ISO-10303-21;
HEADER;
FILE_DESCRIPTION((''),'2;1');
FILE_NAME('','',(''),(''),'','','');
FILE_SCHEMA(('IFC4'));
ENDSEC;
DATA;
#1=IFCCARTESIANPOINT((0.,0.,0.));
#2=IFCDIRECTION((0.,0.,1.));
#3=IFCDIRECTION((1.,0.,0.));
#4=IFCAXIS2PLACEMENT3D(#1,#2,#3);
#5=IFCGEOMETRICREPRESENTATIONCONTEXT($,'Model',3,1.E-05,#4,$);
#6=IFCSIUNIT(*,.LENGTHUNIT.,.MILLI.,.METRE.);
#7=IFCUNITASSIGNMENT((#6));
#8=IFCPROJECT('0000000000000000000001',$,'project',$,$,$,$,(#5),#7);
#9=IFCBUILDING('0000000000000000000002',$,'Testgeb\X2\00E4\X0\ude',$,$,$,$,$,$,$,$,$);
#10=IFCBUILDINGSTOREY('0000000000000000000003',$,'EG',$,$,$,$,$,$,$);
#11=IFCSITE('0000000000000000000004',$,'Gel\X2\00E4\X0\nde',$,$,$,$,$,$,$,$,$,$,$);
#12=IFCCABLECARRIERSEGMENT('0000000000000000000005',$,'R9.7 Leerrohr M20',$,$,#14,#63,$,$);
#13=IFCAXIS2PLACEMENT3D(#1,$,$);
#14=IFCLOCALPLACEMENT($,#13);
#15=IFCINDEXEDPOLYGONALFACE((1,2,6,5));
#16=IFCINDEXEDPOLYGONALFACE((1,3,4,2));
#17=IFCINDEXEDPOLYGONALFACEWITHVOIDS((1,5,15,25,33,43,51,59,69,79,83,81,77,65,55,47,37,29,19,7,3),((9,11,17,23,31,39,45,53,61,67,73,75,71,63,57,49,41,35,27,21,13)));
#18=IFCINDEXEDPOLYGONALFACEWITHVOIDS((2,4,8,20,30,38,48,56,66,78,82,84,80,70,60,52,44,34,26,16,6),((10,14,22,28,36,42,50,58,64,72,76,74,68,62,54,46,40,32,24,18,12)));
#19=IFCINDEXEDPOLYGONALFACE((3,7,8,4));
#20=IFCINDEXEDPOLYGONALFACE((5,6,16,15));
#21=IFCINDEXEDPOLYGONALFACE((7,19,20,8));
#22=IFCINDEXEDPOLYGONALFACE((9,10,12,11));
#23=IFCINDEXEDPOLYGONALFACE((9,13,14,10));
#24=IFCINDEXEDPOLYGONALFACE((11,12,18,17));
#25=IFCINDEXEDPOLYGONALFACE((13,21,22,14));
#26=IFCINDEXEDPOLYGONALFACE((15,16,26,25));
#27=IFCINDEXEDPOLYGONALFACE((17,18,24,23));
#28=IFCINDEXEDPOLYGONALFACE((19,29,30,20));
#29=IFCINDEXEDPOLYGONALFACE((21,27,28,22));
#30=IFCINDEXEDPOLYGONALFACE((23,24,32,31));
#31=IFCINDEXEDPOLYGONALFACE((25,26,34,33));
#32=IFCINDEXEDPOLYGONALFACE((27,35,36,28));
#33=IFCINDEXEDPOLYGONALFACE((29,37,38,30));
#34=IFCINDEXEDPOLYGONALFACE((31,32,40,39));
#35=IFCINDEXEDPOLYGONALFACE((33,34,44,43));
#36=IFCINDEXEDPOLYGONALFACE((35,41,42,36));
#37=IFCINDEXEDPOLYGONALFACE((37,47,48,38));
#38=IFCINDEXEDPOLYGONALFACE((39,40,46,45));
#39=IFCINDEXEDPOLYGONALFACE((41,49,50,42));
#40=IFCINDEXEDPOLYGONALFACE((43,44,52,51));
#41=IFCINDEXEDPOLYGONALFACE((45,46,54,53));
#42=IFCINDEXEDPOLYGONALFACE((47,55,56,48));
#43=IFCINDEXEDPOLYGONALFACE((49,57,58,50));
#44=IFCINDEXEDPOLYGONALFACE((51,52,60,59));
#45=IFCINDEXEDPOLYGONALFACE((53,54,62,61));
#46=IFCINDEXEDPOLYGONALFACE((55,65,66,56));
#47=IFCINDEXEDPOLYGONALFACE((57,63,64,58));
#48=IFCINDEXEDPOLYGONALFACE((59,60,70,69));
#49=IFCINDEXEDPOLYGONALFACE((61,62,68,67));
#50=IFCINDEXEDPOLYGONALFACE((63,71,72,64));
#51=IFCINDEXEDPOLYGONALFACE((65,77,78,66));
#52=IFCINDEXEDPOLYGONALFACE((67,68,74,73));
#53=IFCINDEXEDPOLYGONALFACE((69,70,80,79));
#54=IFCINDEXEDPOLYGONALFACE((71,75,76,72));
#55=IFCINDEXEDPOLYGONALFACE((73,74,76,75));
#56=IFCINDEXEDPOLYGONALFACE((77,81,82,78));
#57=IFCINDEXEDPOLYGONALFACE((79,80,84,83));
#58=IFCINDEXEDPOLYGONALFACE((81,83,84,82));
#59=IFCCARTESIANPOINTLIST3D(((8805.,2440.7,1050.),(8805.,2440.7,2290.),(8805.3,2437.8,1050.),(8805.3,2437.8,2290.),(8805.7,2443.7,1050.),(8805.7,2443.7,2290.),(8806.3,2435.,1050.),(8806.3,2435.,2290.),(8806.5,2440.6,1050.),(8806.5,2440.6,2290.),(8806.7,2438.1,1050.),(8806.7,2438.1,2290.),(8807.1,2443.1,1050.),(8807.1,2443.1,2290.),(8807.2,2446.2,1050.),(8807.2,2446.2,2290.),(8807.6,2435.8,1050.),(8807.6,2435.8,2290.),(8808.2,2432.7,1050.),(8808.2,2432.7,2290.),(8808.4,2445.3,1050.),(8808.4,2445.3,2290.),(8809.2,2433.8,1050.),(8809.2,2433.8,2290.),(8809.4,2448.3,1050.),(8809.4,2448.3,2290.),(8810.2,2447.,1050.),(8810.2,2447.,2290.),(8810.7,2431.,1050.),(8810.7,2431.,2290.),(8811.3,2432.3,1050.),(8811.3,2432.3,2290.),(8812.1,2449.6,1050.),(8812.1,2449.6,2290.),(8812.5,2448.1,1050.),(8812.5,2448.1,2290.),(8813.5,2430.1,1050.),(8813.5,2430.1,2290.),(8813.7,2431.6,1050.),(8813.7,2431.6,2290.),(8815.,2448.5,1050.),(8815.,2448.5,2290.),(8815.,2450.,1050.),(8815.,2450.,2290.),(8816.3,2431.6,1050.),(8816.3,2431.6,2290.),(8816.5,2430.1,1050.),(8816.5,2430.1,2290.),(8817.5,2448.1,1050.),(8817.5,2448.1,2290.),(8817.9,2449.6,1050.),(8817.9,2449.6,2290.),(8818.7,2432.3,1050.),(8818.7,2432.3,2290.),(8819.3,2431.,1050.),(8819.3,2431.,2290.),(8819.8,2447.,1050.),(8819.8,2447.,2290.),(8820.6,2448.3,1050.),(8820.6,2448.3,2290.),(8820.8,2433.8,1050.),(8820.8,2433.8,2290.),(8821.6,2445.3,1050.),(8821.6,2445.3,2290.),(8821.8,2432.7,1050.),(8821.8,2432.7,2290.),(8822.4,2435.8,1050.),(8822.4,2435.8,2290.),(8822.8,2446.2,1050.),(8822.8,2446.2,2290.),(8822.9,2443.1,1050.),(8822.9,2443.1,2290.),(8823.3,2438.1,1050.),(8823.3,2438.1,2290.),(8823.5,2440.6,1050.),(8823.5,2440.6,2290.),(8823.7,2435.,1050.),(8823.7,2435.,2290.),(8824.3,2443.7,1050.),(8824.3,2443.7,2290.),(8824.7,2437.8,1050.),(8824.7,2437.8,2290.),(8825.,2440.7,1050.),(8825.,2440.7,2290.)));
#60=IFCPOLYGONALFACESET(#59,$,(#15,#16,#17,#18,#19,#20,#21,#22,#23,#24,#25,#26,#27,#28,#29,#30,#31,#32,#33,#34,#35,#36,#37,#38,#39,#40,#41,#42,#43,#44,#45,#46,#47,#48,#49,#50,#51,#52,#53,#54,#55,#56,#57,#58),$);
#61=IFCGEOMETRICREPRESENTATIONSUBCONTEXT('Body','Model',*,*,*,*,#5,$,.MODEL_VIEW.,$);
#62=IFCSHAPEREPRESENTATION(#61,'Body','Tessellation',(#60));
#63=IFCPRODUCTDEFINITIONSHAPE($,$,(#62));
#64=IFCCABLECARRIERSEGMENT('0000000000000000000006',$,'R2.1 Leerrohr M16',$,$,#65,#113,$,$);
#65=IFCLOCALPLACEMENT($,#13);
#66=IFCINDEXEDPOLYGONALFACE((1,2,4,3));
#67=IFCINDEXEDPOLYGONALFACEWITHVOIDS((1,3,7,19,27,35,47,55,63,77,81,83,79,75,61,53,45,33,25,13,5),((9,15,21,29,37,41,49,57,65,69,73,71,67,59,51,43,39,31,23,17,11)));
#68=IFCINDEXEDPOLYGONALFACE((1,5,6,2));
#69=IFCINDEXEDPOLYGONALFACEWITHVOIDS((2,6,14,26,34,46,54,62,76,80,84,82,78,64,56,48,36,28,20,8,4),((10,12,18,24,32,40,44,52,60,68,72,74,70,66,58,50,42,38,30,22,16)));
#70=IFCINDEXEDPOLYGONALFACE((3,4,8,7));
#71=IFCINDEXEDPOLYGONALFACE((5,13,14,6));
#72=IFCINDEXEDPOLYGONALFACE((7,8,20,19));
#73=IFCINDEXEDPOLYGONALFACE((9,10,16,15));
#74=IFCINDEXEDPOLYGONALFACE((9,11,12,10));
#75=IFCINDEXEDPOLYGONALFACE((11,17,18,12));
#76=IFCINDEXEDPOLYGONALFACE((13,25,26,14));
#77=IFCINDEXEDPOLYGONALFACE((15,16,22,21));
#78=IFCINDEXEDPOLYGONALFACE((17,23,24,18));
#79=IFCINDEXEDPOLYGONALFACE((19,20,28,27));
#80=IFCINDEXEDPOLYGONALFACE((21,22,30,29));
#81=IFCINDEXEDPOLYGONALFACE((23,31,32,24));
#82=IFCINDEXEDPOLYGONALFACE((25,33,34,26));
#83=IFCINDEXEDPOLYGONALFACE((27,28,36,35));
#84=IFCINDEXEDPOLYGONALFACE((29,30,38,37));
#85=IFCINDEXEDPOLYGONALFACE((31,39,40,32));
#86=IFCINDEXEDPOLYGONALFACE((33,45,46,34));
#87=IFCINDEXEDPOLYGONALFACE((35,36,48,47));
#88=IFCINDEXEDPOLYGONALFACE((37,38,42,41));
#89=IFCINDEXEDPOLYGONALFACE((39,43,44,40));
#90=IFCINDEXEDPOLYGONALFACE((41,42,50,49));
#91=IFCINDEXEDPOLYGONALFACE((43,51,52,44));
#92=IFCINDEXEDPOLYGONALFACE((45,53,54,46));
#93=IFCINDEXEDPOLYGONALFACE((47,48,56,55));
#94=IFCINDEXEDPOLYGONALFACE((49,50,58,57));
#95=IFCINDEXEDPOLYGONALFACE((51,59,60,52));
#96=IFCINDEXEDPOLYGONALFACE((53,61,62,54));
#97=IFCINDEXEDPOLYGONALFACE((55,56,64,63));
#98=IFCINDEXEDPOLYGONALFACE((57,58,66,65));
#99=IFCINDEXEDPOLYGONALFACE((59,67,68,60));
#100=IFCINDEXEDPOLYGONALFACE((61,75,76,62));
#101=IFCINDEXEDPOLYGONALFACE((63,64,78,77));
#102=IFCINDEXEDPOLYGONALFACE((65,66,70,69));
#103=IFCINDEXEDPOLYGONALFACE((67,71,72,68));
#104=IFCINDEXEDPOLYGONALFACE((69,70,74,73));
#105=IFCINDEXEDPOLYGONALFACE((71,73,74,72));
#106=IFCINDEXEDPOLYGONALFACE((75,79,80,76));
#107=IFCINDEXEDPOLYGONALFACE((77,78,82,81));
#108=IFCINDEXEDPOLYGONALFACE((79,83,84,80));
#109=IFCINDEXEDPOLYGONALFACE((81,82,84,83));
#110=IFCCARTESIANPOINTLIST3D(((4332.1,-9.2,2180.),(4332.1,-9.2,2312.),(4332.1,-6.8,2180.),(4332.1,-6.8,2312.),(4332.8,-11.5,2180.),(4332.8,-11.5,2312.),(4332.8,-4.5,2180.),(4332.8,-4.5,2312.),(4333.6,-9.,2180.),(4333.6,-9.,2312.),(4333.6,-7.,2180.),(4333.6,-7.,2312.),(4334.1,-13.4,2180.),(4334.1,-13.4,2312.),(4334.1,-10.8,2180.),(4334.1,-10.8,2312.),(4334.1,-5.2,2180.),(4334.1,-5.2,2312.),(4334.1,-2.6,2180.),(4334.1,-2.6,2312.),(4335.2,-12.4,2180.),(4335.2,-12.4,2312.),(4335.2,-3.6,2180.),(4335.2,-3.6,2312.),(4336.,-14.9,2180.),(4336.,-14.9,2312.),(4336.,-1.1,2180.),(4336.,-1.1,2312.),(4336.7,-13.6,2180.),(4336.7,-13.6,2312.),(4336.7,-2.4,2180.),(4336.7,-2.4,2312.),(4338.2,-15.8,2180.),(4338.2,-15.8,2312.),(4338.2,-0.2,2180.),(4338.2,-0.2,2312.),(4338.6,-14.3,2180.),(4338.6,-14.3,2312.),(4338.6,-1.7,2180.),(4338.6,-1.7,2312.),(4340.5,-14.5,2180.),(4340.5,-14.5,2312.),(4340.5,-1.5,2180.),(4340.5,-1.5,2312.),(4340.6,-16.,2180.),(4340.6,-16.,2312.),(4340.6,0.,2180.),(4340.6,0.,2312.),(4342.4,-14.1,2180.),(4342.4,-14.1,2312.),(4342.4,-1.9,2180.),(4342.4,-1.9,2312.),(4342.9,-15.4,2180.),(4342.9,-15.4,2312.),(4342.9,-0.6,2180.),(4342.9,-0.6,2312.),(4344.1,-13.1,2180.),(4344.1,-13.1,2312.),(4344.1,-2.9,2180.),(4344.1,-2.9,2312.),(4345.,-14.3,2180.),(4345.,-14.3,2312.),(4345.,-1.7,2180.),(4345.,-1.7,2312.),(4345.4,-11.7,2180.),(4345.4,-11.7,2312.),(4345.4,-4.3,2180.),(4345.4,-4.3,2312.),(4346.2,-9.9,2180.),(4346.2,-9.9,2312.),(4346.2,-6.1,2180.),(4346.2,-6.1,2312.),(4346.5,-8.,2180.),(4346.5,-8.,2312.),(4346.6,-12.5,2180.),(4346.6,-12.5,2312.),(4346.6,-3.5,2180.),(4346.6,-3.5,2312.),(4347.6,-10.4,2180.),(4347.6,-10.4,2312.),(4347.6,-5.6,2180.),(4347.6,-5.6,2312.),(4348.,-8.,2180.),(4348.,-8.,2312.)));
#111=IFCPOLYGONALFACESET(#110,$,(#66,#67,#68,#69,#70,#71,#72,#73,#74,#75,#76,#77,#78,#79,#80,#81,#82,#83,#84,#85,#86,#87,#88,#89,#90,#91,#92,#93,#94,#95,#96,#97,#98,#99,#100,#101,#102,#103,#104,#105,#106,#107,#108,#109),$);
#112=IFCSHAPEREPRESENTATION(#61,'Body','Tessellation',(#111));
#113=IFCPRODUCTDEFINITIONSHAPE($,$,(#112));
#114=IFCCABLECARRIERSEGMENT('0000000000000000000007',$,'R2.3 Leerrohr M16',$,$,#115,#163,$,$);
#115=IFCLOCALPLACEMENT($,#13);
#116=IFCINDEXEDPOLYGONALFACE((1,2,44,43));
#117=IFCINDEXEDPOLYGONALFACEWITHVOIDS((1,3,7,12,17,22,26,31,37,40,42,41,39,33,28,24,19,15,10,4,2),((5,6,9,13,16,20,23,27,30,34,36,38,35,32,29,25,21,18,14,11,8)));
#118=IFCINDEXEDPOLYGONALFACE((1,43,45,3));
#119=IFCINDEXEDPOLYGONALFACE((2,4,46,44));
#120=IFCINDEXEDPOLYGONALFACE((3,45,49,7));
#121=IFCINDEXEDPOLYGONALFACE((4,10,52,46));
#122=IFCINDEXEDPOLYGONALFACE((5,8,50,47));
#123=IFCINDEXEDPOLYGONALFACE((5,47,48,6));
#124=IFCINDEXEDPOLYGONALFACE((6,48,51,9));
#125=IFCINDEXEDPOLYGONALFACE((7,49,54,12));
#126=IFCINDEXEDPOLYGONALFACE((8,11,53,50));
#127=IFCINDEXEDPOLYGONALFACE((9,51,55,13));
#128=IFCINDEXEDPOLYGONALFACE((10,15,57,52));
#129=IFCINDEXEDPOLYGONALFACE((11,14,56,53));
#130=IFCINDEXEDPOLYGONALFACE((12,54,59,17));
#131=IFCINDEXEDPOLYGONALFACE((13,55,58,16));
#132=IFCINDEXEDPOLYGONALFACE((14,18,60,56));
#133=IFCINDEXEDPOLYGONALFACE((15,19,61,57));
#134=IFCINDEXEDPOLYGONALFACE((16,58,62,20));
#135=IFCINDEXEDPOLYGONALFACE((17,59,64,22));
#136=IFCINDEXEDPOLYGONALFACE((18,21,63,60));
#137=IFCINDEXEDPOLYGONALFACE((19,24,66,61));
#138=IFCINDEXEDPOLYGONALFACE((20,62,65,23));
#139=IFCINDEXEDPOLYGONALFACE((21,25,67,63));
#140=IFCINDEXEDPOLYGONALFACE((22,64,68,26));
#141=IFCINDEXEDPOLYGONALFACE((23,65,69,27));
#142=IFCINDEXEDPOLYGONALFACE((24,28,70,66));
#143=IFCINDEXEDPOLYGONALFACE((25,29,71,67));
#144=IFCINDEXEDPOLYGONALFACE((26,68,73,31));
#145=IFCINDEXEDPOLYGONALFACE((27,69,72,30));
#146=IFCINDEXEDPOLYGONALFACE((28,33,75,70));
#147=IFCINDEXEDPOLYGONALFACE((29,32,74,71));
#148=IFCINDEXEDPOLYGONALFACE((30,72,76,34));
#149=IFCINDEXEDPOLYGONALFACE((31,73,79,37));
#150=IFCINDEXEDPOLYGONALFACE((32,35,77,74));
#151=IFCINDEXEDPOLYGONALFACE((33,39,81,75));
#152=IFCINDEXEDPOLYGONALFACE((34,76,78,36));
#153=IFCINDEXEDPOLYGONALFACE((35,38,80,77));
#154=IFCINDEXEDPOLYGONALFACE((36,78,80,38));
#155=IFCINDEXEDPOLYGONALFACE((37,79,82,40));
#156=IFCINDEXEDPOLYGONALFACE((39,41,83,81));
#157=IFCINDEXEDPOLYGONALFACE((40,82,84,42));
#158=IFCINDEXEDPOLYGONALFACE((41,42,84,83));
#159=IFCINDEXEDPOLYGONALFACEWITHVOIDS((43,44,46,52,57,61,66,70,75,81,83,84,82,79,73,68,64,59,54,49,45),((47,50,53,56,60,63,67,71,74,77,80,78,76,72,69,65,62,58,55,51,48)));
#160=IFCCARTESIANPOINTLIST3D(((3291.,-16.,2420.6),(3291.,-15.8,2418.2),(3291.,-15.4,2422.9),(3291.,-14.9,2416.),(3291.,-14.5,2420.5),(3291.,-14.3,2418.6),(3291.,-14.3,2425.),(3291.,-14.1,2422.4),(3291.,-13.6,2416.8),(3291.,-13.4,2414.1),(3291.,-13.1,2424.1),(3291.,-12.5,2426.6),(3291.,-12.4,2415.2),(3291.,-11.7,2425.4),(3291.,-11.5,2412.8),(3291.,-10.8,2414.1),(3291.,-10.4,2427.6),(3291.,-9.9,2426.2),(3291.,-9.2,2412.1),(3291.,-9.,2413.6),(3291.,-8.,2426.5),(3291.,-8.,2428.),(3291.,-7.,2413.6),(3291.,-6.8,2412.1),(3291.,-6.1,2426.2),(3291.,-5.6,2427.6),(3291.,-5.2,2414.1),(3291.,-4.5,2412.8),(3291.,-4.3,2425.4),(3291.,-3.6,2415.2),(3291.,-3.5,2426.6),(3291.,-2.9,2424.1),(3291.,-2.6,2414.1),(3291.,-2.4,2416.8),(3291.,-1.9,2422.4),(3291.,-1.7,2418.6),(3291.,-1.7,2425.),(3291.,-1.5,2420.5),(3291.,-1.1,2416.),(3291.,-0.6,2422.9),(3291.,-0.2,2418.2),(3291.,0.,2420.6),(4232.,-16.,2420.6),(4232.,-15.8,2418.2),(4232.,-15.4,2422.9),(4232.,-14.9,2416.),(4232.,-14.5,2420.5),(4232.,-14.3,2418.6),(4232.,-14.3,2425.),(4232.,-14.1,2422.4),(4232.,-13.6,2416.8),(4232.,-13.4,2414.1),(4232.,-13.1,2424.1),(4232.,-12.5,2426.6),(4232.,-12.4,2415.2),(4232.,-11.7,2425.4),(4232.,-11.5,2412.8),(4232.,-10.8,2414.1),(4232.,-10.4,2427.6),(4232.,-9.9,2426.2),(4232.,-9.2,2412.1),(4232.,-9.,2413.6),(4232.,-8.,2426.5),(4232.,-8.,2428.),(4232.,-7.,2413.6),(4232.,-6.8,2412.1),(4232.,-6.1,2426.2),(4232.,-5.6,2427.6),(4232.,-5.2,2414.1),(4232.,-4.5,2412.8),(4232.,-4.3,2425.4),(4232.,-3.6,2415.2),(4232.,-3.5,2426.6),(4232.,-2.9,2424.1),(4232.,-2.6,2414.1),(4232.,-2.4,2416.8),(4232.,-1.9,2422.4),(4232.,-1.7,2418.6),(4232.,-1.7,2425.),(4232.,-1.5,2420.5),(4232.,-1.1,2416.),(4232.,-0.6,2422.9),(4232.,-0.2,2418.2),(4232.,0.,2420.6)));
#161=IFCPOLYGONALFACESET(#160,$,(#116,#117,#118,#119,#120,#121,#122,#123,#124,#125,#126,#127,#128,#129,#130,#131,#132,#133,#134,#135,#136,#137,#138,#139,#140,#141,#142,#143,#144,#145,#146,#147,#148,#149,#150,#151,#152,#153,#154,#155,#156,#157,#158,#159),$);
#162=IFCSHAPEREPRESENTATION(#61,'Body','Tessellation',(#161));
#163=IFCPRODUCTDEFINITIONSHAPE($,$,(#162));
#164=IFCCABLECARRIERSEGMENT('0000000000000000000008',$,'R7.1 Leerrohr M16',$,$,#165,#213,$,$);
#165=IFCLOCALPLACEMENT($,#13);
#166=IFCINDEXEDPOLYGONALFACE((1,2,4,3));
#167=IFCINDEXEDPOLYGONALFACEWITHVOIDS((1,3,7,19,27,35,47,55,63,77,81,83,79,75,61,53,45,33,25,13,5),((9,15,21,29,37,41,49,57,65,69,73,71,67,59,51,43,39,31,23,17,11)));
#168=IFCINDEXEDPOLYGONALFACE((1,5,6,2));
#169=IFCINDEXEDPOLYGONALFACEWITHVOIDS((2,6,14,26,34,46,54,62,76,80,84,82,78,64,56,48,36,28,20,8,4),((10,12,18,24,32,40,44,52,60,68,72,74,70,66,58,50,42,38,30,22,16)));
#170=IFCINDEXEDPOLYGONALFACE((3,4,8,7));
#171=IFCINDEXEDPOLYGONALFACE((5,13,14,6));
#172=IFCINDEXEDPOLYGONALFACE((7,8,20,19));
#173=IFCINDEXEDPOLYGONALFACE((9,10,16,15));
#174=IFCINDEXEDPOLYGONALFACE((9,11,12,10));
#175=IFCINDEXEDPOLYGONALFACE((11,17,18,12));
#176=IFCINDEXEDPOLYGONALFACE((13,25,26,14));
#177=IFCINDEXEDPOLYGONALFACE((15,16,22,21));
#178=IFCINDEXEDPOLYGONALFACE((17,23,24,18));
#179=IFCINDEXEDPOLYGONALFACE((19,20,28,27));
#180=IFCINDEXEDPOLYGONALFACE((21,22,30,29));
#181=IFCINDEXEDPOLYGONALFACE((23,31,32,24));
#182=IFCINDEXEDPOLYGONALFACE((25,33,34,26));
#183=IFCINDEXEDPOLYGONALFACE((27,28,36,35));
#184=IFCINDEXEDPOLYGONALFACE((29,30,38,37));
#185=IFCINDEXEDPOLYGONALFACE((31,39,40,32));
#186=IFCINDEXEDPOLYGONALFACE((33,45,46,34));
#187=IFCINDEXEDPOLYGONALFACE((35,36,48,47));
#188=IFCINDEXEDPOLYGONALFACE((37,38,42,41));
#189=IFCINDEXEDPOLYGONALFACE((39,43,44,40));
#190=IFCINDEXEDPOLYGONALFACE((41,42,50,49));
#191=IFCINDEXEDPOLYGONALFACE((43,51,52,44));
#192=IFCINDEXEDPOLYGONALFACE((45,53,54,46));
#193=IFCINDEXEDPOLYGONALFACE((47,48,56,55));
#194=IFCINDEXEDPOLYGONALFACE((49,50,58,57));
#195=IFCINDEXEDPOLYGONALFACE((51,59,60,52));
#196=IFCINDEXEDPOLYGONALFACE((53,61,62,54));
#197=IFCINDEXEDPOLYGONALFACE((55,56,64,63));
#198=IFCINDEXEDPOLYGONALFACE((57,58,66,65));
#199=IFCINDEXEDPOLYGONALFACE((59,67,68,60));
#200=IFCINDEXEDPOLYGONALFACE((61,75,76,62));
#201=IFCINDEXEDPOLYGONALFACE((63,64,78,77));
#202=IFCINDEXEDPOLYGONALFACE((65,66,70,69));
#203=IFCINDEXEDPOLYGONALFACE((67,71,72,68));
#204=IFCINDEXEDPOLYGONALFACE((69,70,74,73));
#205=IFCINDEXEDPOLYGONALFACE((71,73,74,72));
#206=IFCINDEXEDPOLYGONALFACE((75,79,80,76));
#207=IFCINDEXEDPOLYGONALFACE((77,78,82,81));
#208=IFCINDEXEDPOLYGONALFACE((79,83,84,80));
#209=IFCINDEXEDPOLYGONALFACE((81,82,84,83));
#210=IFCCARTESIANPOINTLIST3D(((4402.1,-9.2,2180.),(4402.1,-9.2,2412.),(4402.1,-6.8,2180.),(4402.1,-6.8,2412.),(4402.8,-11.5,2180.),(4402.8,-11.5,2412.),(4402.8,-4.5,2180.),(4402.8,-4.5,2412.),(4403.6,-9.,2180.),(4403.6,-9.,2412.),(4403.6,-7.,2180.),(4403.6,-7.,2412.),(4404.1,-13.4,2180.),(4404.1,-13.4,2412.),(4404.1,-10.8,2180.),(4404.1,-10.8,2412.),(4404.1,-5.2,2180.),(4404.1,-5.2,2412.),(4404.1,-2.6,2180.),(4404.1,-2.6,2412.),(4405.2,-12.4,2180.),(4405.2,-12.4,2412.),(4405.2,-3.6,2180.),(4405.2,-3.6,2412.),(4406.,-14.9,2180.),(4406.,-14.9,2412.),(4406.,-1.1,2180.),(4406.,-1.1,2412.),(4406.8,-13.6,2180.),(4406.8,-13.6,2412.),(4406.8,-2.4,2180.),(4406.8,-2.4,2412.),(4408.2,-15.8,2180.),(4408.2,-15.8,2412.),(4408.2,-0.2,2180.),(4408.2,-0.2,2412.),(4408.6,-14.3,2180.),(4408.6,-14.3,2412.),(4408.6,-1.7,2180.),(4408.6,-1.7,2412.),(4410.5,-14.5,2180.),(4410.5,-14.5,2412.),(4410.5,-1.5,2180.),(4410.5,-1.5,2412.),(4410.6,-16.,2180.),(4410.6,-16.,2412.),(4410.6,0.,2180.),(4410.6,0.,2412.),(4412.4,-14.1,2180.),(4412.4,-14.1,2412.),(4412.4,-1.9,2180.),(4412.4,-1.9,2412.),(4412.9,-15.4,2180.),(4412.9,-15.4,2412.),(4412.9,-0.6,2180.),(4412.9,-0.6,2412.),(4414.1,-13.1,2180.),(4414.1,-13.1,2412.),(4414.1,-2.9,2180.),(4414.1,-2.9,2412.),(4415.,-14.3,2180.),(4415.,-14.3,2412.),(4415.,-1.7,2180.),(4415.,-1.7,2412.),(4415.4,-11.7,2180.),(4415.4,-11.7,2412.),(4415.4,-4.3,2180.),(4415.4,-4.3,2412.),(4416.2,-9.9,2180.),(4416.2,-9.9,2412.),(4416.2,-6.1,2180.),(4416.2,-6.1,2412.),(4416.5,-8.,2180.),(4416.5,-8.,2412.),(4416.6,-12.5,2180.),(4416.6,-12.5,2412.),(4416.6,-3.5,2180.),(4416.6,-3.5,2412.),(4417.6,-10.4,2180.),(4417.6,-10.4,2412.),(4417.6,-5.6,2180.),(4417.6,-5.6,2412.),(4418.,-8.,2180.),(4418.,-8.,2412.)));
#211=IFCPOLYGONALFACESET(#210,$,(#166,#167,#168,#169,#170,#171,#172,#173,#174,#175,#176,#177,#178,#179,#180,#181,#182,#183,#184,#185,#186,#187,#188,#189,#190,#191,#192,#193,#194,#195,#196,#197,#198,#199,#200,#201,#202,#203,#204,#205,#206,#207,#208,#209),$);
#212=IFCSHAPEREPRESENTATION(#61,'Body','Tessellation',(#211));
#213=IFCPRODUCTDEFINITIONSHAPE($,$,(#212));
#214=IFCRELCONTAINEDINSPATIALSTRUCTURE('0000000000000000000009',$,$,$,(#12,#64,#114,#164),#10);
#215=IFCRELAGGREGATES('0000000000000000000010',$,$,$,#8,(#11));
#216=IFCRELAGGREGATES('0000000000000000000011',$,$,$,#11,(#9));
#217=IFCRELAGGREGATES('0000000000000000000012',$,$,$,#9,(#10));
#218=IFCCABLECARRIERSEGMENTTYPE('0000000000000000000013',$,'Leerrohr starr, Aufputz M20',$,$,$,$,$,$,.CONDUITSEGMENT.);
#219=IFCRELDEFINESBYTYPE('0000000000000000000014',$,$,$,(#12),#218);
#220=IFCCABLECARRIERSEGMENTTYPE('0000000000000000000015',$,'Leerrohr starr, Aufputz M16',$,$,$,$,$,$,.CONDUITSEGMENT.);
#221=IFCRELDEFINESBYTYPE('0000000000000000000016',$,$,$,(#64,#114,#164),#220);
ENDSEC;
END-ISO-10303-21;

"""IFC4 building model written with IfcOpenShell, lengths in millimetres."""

from ifc_helpers import new_model, si_unit, frame, origin_with_axes, place, context, subcontext, project, spatial, hollow_circle, extrude, type_object, element, save


model = new_model("IFC4")

# Units and contexts
model_context = context("Model", 3, precision=1e-05, world=origin_with_axes())
body_context = subcontext(model_context, "Body", "Model", "MODEL_VIEW")
ifc_project = project(units=[si_unit("LENGTHUNIT", "METRE", prefix="MILLI")], contexts=[model_context])

# Site, building, storey
site = spatial("IfcSite", under=ifc_project, Name="Gelände")
building = spatial("IfcBuilding", under=site, Name="Testgebäude")
storey = spatial("IfcBuildingStorey", under=building, Name="EG")

# Cable carrier segment
cable_carrier_segment_type_1 = type_object("IfcCableCarrierSegmentType", Name="Leerrohr starr, Aufputz M20", PredefinedType="CONDUITSEGMENT")
cable_carrier_segment_1_placement = place(None, frame((8815.0, 2440.0, 2290.0), z_axis=(0.0, 0.0, -1.0), x_axis=(0.0, 1.0, 0.0)))
element("IfcCableCarrierSegment", 1, at=cable_carrier_segment_1_placement, inside=storey, type_object=cable_carrier_segment_type_1, Name="R9.7 Leerrohr M20", context=body_context, shape_type="SweptSolid", body=[
    extrude(hollow_circle(Radius=10.0, WallThickness=1.5), None, (0.0, 0.0, 1.0), 1240.0),
])

# Cable carrier segments
cable_carrier_segment_type_2 = type_object("IfcCableCarrierSegmentType", Name="Leerrohr starr, Aufputz M16", PredefinedType="CONDUITSEGMENT")
cable_carrier_segment_2_placement = place(None, frame((4340.0, -8.0, 2180.0), z_axis=(0.0, 0.0, 1.0), x_axis=(1.0, 0.0, 0.0)))
element("IfcCableCarrierSegment", 2, at=cable_carrier_segment_2_placement, inside=storey, type_object=cable_carrier_segment_type_2, Name="R2.1 Leerrohr M16", context=body_context, shape_type="SweptSolid", body=[
    extrude(hollow_circle(Radius=8.0, WallThickness=1.5), None, (0.0, 0.0, 1.0), 132.0),
])
cable_carrier_segment_3_placement = place(None, frame((4232.0, -8.0, 2420.0), z_axis=(-1.0, 0.0, 0.0), x_axis=(0.0, 0.0, 1.0)))
element("IfcCableCarrierSegment", 3, at=cable_carrier_segment_3_placement, inside=storey, type_object=cable_carrier_segment_type_2, Name="R2.3 Leerrohr M16", context=body_context, shape_type="SweptSolid", body=[
    extrude(hollow_circle(Radius=8.0, WallThickness=1.5), None, (0.0, 0.0, 1.0), 941.0),
])
cable_carrier_segment_4_placement = place(None, frame((4410.0, -8.0, 2180.0), z_axis=(0.0, 0.0, 1.0), x_axis=(1.0, 0.0, 0.0)))
element("IfcCableCarrierSegment", 4, at=cable_carrier_segment_4_placement, inside=storey, type_object=cable_carrier_segment_type_2, Name="R7.1 Leerrohr M16", context=body_context, shape_type="SweptSolid", body=[
    extrude(hollow_circle(Radius=8.0, WallThickness=1.5), None, (0.0, 0.0, 1.0), 232.0),
])

save(model, "model.ifc")
